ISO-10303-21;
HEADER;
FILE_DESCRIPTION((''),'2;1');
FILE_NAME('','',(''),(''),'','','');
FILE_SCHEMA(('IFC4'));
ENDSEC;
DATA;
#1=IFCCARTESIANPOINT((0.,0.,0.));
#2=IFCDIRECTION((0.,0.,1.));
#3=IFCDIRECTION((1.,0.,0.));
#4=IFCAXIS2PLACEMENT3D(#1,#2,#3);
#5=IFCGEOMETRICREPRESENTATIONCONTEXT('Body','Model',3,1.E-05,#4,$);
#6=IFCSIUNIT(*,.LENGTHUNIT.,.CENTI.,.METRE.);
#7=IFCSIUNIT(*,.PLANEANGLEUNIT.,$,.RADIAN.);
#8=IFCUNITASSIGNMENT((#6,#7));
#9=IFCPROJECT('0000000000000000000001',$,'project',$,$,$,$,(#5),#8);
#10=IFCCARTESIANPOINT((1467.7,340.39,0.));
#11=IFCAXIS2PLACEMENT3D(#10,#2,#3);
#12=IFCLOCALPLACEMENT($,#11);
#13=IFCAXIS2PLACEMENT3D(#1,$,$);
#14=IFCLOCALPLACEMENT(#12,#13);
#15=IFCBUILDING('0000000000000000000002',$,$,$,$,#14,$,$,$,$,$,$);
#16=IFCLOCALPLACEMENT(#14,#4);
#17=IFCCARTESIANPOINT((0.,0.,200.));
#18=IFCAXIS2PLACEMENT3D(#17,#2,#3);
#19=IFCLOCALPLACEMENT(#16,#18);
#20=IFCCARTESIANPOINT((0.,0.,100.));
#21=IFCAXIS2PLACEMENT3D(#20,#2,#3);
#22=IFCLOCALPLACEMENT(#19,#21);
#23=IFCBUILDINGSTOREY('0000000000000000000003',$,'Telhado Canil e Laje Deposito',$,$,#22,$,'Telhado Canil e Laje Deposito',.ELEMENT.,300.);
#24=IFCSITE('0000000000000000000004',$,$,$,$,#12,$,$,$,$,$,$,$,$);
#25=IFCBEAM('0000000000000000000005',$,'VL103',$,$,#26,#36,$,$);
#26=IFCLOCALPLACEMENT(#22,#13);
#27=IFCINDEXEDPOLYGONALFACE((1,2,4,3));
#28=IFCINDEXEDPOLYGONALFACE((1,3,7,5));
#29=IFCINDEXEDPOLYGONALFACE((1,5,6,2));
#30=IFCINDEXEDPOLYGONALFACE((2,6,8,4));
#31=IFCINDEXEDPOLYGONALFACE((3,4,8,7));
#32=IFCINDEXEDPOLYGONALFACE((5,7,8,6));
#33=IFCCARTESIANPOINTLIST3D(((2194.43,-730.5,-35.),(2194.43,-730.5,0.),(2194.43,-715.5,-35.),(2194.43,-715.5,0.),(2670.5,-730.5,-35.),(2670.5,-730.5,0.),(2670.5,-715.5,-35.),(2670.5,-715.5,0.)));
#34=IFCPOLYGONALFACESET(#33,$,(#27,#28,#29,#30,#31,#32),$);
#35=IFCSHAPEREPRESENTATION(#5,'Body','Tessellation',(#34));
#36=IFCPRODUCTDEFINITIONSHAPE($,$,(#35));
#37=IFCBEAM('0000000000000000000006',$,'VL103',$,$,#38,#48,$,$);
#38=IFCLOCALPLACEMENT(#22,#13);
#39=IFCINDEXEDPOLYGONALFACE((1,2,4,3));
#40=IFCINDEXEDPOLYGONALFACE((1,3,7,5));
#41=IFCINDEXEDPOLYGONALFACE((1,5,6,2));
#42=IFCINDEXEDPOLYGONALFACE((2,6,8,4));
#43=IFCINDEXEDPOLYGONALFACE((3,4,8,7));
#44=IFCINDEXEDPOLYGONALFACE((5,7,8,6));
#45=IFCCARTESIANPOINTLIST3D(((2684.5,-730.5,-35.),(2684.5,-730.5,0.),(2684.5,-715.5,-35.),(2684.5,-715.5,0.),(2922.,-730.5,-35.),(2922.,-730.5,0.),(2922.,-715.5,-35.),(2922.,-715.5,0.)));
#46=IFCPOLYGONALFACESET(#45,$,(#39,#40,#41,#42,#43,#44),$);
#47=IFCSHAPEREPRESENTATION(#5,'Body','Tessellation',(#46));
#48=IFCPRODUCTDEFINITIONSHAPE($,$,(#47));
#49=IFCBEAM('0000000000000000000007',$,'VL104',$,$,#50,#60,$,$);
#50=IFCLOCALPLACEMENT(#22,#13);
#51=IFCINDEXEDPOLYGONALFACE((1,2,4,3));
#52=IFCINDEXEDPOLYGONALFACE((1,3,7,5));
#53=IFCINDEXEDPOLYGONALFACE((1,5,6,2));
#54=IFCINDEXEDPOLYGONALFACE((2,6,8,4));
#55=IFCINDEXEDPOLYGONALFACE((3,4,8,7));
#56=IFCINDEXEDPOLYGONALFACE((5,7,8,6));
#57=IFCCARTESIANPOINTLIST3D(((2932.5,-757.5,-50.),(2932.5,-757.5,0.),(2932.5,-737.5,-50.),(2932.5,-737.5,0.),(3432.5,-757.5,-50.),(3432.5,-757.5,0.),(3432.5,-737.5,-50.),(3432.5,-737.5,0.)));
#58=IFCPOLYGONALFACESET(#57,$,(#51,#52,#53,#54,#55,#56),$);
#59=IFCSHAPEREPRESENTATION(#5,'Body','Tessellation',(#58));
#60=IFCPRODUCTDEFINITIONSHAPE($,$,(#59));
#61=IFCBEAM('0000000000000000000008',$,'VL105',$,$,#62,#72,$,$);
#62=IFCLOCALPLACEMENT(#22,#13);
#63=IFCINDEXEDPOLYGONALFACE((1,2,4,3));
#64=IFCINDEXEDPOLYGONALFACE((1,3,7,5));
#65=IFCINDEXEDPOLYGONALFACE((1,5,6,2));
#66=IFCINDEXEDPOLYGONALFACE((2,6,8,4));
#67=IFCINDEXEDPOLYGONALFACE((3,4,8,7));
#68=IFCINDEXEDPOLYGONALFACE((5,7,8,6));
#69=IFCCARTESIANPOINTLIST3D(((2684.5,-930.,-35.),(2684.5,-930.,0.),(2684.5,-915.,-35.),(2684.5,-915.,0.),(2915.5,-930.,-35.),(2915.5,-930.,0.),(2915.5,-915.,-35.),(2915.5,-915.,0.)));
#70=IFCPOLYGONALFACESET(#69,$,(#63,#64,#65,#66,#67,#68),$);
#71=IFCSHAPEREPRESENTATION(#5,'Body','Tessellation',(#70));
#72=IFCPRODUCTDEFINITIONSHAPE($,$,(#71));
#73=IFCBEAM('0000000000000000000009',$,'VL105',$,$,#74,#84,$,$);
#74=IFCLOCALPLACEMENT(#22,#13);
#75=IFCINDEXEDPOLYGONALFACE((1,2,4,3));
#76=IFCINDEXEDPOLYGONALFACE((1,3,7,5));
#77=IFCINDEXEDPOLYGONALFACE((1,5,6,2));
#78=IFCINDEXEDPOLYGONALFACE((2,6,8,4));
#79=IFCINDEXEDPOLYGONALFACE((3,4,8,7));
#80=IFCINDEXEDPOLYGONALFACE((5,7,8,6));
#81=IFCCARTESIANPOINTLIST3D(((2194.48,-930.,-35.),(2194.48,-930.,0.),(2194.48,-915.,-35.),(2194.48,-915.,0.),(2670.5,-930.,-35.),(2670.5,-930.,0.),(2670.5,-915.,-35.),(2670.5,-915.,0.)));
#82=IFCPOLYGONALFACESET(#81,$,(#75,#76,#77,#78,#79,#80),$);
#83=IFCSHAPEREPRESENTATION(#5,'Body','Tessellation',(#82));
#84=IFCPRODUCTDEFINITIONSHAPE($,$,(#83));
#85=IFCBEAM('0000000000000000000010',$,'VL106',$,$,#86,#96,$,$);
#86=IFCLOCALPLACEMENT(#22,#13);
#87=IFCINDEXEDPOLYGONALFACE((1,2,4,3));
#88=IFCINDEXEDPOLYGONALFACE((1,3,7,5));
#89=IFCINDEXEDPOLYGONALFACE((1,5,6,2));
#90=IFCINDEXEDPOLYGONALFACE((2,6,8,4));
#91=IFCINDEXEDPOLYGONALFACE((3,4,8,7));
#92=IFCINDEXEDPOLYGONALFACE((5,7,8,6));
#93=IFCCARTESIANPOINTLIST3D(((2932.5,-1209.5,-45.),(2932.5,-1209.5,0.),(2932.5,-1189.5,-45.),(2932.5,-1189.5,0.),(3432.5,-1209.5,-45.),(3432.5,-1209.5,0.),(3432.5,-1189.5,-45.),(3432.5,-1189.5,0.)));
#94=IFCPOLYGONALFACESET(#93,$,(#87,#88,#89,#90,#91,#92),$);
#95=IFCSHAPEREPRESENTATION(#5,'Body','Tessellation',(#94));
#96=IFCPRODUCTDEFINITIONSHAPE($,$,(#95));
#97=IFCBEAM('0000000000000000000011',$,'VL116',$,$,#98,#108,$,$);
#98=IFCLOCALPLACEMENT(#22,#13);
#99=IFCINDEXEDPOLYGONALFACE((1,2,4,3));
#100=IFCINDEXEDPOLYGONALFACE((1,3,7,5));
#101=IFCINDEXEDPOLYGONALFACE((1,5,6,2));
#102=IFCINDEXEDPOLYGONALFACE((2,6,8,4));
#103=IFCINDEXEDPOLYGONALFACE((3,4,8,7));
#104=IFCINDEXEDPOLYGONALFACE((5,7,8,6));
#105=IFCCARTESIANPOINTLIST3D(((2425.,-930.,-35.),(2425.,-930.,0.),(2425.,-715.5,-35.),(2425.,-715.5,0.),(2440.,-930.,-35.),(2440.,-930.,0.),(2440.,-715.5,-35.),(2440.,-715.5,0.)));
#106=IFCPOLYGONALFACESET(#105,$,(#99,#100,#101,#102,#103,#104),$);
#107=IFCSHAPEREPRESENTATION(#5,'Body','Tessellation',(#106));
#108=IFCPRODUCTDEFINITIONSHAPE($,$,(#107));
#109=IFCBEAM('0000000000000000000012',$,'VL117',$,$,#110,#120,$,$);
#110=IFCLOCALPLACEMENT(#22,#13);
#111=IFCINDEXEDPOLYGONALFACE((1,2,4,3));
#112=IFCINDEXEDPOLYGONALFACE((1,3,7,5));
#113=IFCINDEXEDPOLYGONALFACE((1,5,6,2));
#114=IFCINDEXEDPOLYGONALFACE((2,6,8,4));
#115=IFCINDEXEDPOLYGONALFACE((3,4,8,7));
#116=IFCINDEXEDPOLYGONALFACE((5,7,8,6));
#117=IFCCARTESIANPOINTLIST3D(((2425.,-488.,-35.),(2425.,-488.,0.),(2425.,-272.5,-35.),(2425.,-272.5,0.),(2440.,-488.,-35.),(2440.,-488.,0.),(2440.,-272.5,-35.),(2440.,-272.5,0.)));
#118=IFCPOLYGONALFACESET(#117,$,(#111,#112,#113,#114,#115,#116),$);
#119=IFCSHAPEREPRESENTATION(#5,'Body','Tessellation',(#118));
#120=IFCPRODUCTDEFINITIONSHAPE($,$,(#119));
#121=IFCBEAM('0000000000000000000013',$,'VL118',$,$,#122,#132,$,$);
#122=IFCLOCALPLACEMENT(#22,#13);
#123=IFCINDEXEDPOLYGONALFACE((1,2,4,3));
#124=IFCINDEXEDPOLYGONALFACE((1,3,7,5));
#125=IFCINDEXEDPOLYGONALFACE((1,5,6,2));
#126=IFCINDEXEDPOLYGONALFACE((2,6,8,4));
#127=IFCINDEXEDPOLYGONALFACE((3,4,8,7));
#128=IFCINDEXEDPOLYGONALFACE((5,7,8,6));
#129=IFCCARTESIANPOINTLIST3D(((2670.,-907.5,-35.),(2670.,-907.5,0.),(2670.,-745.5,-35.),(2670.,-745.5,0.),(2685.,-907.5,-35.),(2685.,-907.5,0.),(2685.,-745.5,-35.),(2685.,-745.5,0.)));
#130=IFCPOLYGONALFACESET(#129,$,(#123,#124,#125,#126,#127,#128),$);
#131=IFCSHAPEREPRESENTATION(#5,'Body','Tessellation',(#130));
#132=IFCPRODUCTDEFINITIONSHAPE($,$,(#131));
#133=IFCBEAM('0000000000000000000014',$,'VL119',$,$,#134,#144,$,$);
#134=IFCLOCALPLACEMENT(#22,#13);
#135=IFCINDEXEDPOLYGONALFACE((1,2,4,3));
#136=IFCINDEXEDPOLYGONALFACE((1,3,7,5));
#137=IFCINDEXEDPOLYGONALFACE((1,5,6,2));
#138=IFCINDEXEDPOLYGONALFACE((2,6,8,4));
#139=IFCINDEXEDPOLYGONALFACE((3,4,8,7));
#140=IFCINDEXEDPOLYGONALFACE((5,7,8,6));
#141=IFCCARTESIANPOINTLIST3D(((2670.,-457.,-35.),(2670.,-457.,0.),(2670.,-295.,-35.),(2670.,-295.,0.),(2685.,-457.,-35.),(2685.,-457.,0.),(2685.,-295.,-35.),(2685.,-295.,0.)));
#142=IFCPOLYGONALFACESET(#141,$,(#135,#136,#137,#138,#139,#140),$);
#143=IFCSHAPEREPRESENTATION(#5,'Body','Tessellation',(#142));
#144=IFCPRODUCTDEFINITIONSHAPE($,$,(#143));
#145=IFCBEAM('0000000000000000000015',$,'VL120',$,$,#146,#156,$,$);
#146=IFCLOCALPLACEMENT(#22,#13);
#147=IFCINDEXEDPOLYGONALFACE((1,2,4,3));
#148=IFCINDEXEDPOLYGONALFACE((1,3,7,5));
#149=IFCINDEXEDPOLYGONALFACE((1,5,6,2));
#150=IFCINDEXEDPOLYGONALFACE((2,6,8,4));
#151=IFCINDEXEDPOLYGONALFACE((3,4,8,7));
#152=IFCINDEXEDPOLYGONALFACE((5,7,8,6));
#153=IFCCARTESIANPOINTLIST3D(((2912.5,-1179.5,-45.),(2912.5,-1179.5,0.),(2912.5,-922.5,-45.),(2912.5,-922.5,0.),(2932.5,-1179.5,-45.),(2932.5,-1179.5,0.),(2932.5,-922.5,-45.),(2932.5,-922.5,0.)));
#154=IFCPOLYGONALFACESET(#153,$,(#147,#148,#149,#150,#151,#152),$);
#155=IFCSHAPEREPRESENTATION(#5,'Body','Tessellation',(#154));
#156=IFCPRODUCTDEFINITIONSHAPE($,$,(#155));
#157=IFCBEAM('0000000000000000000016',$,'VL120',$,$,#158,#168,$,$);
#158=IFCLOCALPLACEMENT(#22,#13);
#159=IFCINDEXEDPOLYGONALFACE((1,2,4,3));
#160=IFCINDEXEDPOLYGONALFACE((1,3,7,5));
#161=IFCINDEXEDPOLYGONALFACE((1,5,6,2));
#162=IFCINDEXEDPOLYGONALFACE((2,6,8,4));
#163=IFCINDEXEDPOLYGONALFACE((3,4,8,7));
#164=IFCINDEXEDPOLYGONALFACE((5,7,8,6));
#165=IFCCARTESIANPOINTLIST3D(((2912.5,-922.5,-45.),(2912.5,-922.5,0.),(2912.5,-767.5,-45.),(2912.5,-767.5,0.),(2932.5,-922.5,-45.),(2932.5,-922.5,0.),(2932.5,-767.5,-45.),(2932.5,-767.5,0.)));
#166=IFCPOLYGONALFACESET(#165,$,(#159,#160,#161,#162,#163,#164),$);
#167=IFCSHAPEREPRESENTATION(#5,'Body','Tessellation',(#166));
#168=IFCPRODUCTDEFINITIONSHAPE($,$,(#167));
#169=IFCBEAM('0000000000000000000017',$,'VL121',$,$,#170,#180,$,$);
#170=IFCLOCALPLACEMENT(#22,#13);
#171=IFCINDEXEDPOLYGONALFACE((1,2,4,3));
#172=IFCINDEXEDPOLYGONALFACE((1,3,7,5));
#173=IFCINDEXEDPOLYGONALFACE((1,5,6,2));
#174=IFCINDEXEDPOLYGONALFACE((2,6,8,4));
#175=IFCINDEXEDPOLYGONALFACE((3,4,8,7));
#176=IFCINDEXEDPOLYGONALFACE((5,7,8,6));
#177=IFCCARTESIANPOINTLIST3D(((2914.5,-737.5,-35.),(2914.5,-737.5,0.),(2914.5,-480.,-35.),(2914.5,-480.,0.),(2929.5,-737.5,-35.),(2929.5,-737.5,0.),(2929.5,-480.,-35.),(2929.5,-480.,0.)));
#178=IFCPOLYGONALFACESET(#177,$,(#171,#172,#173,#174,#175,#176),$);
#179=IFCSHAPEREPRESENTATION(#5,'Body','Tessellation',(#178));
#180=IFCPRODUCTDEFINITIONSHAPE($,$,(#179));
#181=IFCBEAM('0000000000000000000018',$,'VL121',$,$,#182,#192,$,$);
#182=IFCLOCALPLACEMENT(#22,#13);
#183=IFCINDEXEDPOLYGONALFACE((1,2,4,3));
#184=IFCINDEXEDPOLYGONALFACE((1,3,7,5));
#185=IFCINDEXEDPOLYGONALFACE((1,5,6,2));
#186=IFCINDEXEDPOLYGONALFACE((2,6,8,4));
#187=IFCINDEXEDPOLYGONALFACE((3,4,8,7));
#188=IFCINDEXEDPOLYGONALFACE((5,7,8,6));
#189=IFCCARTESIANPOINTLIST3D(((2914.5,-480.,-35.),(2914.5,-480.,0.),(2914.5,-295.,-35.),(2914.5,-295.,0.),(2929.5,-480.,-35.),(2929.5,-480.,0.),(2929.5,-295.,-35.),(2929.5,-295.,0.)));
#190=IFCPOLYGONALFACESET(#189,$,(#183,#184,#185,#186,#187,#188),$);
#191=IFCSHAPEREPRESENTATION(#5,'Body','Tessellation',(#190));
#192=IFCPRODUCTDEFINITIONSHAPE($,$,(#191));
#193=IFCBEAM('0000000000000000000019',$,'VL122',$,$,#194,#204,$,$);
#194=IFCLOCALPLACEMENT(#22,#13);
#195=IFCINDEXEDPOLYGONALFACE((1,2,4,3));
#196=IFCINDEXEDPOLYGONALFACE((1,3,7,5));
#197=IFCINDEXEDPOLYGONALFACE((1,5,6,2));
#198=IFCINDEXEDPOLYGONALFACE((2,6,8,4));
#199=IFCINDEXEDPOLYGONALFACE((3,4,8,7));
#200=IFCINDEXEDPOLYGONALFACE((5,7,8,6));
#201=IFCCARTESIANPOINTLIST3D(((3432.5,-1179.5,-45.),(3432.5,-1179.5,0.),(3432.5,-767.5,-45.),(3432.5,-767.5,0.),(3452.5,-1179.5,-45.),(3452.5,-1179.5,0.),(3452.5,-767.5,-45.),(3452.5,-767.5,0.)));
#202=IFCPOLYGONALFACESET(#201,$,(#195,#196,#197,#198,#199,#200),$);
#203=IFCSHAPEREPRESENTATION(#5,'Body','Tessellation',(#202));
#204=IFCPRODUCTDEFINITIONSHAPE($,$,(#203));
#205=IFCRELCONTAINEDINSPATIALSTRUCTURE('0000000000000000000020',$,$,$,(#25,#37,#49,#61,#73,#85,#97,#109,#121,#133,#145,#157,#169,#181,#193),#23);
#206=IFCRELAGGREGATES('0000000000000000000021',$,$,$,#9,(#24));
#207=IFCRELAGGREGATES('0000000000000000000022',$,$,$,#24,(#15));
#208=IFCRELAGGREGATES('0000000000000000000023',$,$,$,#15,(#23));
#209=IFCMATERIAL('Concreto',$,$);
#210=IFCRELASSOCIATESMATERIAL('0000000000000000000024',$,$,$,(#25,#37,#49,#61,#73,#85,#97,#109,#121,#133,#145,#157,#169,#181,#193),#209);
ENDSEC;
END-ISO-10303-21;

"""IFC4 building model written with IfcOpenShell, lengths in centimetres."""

from ifc_helpers import new_model, si_unit, frame, origin, origin_with_axes, origin_2d_with_axis, place, context, project, spatial, rectangle, extrude, material, element, save


model = new_model("IFC4")

# Units and contexts
model_context = context("Model", 3, precision=1e-05, world=origin_with_axes(), identifier="Body")
ifc_project = project(units=[si_unit("LENGTHUNIT", "METRE", prefix="CENTI"), si_unit("PLANEANGLEUNIT", "RADIAN")], contexts=[model_context])

# Site, building, storey
site_placement = place(None, frame((1467.7, 340.39, 0.0), z_axis=(0.0, 0.0, 1.0), x_axis=(1.0, 0.0, 0.0)))
site = spatial("IfcSite", under=ifc_project, at=site_placement)
building_placement = place(site_placement, origin())
building = spatial("IfcBuilding", under=site, at=building_placement)
placement_1 = place(building_placement, origin_with_axes())
placement_2 = place(placement_1, frame((0.0, 0.0, 200.0), z_axis=(0.0, 0.0, 1.0), x_axis=(1.0, 0.0, 0.0)))
storey_placement = place(placement_2, frame((0.0, 0.0, 100.0), z_axis=(0.0, 0.0, 1.0), x_axis=(1.0, 0.0, 0.0)))
storey = spatial("IfcBuildingStorey", under=building, at=storey_placement, Name="Telhado Canil e Laje Deposito", LongName="Telhado Canil e Laje Deposito", CompositionType="ELEMENT", Elevation=300.0)

# Shared definitions
ifc_material = material(Name="Concreto")

# Beams
beam_1_placement = place(storey_placement, frame((2432.47, -723.0, 0.0), z_axis=(0.0, 0.0, 1.0), x_axis=(1.0, 0.0, 0.0)))
element("IfcBeam", 1, at=beam_1_placement, inside=storey, material=ifc_material, Name="VL103", context=model_context, shape_type="SolidModel", body=[
    extrude(rectangle(XDim=15.0, YDim=35.0, at=origin_2d_with_axis()), frame((-238.03, 0.0, -17.5), z_axis=(1.0, 0.0, 0.0), x_axis=(0.0, 1.0, 0.0)), (0.0, 0.0, 1.0), 476.07),
])
beam_2_placement = place(storey_placement, frame((2803.25, -723.0, 0.0), z_axis=(0.0, 0.0, 1.0), x_axis=(1.0, 0.0, 0.0)))
element("IfcBeam", 2, at=beam_2_placement, inside=storey, material=ifc_material, Name="VL103", context=model_context, shape_type="SolidModel", body=[
    extrude(rectangle(XDim=15.0, YDim=35.0, at=origin_2d_with_axis()), frame((-118.75, 0.0, -17.5), z_axis=(1.0, 0.0, 0.0), x_axis=(0.0, 1.0, 0.0)), (0.0, 0.0, 1.0), 237.5),
])
beam_3_placement = place(storey_placement, frame((3182.5, -747.5, 0.0), z_axis=(0.0, 0.0, 1.0), x_axis=(1.0, 0.0, 0.0)))
element("IfcBeam", 3, at=beam_3_placement, inside=storey, material=ifc_material, Name="VL104", context=model_context, shape_type="SolidModel", body=[
    extrude(rectangle(XDim=20.0, YDim=50.0, at=origin_2d_with_axis()), frame((-250.0, 0.0, -25.0), z_axis=(1.0, 0.0, 0.0), x_axis=(0.0, 1.0, 0.0)), (0.0, 0.0, 1.0), 500.0),
])
beam_4_placement = place(storey_placement, frame((2800.0, -922.5, 0.0), z_axis=(0.0, 0.0, 1.0), x_axis=(1.0, 0.0, 0.0)))
element("IfcBeam", 4, at=beam_4_placement, inside=storey, material=ifc_material, Name="VL105", context=model_context, shape_type="SolidModel", body=[
    extrude(rectangle(XDim=15.0, YDim=35.0, at=origin_2d_with_axis()), frame((-115.5, 0.0, -17.5), z_axis=(1.0, 0.0, 0.0), x_axis=(0.0, 1.0, 0.0)), (0.0, 0.0, 1.0), 231.0),
])
beam_5_placement = place(storey_placement, frame((2432.49, -922.5, 0.0), z_axis=(0.0, 0.0, 1.0), x_axis=(1.0, 0.0, 0.0)))
element("IfcBeam", 5, at=beam_5_placement, inside=storey, material=ifc_material, Name="VL105", context=model_context, shape_type="SolidModel", body=[
    extrude(rectangle(XDim=15.0, YDim=35.0, at=origin_2d_with_axis()), frame((-238.01, 0.0, -17.5), z_axis=(1.0, 0.0, 0.0), x_axis=(0.0, 1.0, 0.0)), (0.0, 0.0, 1.0), 476.02),
])
beam_6_placement = place(storey_placement, frame((3182.5, -1199.5, 0.0), z_axis=(0.0, 0.0, 1.0), x_axis=(1.0, 0.0, 0.0)))
element("IfcBeam", 6, at=beam_6_placement, inside=storey, material=ifc_material, Name="VL106", context=model_context, shape_type="SolidModel", body=[
    extrude(rectangle(XDim=20.0, YDim=45.0, at=origin_2d_with_axis()), frame((-250.0, 0.0, -22.5), z_axis=(1.0, 0.0, 0.0), x_axis=(0.0, 1.0, 0.0)), (0.0, 0.0, 1.0), 500.0),
])
beam_7_placement = place(storey_placement, frame((2432.5, -822.75, 0.0), z_axis=(0.0, 0.0, 1.0), x_axis=(1.0, 0.0, 0.0)))
element("IfcBeam", 7, at=beam_7_placement, inside=storey, material=ifc_material, Name="VL116", context=model_context, shape_type="SolidModel", body=[
    extrude(rectangle(XDim=15.0, YDim=35.0, at=origin_2d_with_axis()), frame((0.0, -107.25, -17.5), z_axis=(0.0, 1.0, 0.0), x_axis=(1.0, 0.0, 0.0)), (0.0, 0.0, 1.0), 214.5),
])
beam_8_placement = place(storey_placement, frame((2432.5, -380.25, 0.0), z_axis=(0.0, 0.0, 1.0), x_axis=(1.0, 0.0, 0.0)))
element("IfcBeam", 8, at=beam_8_placement, inside=storey, material=ifc_material, Name="VL117", context=model_context, shape_type="SolidModel", body=[
    extrude(rectangle(XDim=15.0, YDim=35.0, at=origin_2d_with_axis()), frame((0.0, -107.75, -17.5), z_axis=(0.0, 1.0, 0.0), x_axis=(1.0, 0.0, 0.0)), (0.0, 0.0, 1.0), 215.5),
])
for number, where, z_axis, x_axis, name in (
    (9, (2677.5, -826.5, 0.0), (0.0, 0.0, 1.0), (1.0, 0.0, 0.0), "VL118"),
    (10, (2677.5, -376.0, 0.0), (0.0, 0.0, 1.0), (1.0, 0.0, 0.0), "VL119"),
):
    element("IfcBeam", number, at=place(storey_placement, frame(where, z_axis=z_axis, x_axis=x_axis)), inside=storey, material=ifc_material, Name=name, context=model_context, shape_type="SolidModel", body=[
        extrude(rectangle(XDim=15.0, YDim=35.0, at=origin_2d_with_axis()), frame((0.0, -81.0, -17.5), z_axis=(0.0, 1.0, 0.0), x_axis=(1.0, 0.0, 0.0)), (0.0, 0.0, 1.0), 162.0),
    ])
beam_9_placement = place(storey_placement, frame((2922.5, -1051.0, 0.0), z_axis=(0.0, 0.0, 1.0), x_axis=(1.0, 0.0, 0.0)))
element("IfcBeam", 11, at=beam_9_placement, inside=storey, material=ifc_material, Name="VL120", context=model_context, shape_type="SolidModel", body=[
    extrude(rectangle(XDim=20.0, YDim=45.0, at=origin_2d_with_axis()), frame((0.0, -128.5, -22.5), z_axis=(0.0, 1.0, 0.0), x_axis=(1.0, 0.0, 0.0)), (0.0, 0.0, 1.0), 257.0),
])
beam_10_placement = place(storey_placement, frame((2922.5, -845.0, 0.0), z_axis=(0.0, 0.0, 1.0), x_axis=(1.0, 0.0, 0.0)))
element("IfcBeam", 12, at=beam_10_placement, inside=storey, material=ifc_material, Name="VL120", context=model_context, shape_type="SolidModel", body=[
    extrude(rectangle(XDim=20.0, YDim=45.0, at=origin_2d_with_axis()), frame((0.0, -77.5, -22.5), z_axis=(0.0, 1.0, 0.0), x_axis=(1.0, 0.0, 0.0)), (0.0, 0.0, 1.0), 155.0),
])
beam_11_placement = place(storey_placement, frame((2922.0, -608.75, 0.0), z_axis=(0.0, 0.0, 1.0), x_axis=(1.0, 0.0, 0.0)))
element("IfcBeam", 13, at=beam_11_placement, inside=storey, material=ifc_material, Name="VL121", context=model_context, shape_type="SolidModel", body=[
    extrude(rectangle(XDim=15.0, YDim=35.0, at=origin_2d_with_axis()), frame((0.0, -128.75, -17.5), z_axis=(0.0, 1.0, 0.0), x_axis=(1.0, 0.0, 0.0)), (0.0, 0.0, 1.0), 257.5),
])
beam_12_placement = place(storey_placement, frame((2922.0, -387.5, 0.0), z_axis=(0.0, 0.0, 1.0), x_axis=(1.0, 0.0, 0.0)))
element("IfcBeam", 14, at=beam_12_placement, inside=storey, material=ifc_material, Name="VL121", context=model_context, shape_type="SolidModel", body=[
    extrude(rectangle(XDim=15.0, YDim=35.0, at=origin_2d_with_axis()), frame((0.0, -92.5, -17.5), z_axis=(0.0, 1.0, 0.0), x_axis=(1.0, 0.0, 0.0)), (0.0, 0.0, 1.0), 185.0),
])
beam_13_placement = place(storey_placement, frame((3442.5, -973.5, 0.0), z_axis=(0.0, 0.0, 1.0), x_axis=(1.0, 0.0, 0.0)))
element("IfcBeam", 15, at=beam_13_placement, inside=storey, material=ifc_material, Name="VL122", context=model_context, shape_type="SolidModel", body=[
    extrude(rectangle(XDim=20.0, YDim=45.0, at=origin_2d_with_axis()), frame((0.0, -206.0, -22.5), z_axis=(0.0, 1.0, 0.0), x_axis=(1.0, 0.0, 0.0)), (0.0, 0.0, 1.0), 412.0),
])

save(model, "model.ifc")
